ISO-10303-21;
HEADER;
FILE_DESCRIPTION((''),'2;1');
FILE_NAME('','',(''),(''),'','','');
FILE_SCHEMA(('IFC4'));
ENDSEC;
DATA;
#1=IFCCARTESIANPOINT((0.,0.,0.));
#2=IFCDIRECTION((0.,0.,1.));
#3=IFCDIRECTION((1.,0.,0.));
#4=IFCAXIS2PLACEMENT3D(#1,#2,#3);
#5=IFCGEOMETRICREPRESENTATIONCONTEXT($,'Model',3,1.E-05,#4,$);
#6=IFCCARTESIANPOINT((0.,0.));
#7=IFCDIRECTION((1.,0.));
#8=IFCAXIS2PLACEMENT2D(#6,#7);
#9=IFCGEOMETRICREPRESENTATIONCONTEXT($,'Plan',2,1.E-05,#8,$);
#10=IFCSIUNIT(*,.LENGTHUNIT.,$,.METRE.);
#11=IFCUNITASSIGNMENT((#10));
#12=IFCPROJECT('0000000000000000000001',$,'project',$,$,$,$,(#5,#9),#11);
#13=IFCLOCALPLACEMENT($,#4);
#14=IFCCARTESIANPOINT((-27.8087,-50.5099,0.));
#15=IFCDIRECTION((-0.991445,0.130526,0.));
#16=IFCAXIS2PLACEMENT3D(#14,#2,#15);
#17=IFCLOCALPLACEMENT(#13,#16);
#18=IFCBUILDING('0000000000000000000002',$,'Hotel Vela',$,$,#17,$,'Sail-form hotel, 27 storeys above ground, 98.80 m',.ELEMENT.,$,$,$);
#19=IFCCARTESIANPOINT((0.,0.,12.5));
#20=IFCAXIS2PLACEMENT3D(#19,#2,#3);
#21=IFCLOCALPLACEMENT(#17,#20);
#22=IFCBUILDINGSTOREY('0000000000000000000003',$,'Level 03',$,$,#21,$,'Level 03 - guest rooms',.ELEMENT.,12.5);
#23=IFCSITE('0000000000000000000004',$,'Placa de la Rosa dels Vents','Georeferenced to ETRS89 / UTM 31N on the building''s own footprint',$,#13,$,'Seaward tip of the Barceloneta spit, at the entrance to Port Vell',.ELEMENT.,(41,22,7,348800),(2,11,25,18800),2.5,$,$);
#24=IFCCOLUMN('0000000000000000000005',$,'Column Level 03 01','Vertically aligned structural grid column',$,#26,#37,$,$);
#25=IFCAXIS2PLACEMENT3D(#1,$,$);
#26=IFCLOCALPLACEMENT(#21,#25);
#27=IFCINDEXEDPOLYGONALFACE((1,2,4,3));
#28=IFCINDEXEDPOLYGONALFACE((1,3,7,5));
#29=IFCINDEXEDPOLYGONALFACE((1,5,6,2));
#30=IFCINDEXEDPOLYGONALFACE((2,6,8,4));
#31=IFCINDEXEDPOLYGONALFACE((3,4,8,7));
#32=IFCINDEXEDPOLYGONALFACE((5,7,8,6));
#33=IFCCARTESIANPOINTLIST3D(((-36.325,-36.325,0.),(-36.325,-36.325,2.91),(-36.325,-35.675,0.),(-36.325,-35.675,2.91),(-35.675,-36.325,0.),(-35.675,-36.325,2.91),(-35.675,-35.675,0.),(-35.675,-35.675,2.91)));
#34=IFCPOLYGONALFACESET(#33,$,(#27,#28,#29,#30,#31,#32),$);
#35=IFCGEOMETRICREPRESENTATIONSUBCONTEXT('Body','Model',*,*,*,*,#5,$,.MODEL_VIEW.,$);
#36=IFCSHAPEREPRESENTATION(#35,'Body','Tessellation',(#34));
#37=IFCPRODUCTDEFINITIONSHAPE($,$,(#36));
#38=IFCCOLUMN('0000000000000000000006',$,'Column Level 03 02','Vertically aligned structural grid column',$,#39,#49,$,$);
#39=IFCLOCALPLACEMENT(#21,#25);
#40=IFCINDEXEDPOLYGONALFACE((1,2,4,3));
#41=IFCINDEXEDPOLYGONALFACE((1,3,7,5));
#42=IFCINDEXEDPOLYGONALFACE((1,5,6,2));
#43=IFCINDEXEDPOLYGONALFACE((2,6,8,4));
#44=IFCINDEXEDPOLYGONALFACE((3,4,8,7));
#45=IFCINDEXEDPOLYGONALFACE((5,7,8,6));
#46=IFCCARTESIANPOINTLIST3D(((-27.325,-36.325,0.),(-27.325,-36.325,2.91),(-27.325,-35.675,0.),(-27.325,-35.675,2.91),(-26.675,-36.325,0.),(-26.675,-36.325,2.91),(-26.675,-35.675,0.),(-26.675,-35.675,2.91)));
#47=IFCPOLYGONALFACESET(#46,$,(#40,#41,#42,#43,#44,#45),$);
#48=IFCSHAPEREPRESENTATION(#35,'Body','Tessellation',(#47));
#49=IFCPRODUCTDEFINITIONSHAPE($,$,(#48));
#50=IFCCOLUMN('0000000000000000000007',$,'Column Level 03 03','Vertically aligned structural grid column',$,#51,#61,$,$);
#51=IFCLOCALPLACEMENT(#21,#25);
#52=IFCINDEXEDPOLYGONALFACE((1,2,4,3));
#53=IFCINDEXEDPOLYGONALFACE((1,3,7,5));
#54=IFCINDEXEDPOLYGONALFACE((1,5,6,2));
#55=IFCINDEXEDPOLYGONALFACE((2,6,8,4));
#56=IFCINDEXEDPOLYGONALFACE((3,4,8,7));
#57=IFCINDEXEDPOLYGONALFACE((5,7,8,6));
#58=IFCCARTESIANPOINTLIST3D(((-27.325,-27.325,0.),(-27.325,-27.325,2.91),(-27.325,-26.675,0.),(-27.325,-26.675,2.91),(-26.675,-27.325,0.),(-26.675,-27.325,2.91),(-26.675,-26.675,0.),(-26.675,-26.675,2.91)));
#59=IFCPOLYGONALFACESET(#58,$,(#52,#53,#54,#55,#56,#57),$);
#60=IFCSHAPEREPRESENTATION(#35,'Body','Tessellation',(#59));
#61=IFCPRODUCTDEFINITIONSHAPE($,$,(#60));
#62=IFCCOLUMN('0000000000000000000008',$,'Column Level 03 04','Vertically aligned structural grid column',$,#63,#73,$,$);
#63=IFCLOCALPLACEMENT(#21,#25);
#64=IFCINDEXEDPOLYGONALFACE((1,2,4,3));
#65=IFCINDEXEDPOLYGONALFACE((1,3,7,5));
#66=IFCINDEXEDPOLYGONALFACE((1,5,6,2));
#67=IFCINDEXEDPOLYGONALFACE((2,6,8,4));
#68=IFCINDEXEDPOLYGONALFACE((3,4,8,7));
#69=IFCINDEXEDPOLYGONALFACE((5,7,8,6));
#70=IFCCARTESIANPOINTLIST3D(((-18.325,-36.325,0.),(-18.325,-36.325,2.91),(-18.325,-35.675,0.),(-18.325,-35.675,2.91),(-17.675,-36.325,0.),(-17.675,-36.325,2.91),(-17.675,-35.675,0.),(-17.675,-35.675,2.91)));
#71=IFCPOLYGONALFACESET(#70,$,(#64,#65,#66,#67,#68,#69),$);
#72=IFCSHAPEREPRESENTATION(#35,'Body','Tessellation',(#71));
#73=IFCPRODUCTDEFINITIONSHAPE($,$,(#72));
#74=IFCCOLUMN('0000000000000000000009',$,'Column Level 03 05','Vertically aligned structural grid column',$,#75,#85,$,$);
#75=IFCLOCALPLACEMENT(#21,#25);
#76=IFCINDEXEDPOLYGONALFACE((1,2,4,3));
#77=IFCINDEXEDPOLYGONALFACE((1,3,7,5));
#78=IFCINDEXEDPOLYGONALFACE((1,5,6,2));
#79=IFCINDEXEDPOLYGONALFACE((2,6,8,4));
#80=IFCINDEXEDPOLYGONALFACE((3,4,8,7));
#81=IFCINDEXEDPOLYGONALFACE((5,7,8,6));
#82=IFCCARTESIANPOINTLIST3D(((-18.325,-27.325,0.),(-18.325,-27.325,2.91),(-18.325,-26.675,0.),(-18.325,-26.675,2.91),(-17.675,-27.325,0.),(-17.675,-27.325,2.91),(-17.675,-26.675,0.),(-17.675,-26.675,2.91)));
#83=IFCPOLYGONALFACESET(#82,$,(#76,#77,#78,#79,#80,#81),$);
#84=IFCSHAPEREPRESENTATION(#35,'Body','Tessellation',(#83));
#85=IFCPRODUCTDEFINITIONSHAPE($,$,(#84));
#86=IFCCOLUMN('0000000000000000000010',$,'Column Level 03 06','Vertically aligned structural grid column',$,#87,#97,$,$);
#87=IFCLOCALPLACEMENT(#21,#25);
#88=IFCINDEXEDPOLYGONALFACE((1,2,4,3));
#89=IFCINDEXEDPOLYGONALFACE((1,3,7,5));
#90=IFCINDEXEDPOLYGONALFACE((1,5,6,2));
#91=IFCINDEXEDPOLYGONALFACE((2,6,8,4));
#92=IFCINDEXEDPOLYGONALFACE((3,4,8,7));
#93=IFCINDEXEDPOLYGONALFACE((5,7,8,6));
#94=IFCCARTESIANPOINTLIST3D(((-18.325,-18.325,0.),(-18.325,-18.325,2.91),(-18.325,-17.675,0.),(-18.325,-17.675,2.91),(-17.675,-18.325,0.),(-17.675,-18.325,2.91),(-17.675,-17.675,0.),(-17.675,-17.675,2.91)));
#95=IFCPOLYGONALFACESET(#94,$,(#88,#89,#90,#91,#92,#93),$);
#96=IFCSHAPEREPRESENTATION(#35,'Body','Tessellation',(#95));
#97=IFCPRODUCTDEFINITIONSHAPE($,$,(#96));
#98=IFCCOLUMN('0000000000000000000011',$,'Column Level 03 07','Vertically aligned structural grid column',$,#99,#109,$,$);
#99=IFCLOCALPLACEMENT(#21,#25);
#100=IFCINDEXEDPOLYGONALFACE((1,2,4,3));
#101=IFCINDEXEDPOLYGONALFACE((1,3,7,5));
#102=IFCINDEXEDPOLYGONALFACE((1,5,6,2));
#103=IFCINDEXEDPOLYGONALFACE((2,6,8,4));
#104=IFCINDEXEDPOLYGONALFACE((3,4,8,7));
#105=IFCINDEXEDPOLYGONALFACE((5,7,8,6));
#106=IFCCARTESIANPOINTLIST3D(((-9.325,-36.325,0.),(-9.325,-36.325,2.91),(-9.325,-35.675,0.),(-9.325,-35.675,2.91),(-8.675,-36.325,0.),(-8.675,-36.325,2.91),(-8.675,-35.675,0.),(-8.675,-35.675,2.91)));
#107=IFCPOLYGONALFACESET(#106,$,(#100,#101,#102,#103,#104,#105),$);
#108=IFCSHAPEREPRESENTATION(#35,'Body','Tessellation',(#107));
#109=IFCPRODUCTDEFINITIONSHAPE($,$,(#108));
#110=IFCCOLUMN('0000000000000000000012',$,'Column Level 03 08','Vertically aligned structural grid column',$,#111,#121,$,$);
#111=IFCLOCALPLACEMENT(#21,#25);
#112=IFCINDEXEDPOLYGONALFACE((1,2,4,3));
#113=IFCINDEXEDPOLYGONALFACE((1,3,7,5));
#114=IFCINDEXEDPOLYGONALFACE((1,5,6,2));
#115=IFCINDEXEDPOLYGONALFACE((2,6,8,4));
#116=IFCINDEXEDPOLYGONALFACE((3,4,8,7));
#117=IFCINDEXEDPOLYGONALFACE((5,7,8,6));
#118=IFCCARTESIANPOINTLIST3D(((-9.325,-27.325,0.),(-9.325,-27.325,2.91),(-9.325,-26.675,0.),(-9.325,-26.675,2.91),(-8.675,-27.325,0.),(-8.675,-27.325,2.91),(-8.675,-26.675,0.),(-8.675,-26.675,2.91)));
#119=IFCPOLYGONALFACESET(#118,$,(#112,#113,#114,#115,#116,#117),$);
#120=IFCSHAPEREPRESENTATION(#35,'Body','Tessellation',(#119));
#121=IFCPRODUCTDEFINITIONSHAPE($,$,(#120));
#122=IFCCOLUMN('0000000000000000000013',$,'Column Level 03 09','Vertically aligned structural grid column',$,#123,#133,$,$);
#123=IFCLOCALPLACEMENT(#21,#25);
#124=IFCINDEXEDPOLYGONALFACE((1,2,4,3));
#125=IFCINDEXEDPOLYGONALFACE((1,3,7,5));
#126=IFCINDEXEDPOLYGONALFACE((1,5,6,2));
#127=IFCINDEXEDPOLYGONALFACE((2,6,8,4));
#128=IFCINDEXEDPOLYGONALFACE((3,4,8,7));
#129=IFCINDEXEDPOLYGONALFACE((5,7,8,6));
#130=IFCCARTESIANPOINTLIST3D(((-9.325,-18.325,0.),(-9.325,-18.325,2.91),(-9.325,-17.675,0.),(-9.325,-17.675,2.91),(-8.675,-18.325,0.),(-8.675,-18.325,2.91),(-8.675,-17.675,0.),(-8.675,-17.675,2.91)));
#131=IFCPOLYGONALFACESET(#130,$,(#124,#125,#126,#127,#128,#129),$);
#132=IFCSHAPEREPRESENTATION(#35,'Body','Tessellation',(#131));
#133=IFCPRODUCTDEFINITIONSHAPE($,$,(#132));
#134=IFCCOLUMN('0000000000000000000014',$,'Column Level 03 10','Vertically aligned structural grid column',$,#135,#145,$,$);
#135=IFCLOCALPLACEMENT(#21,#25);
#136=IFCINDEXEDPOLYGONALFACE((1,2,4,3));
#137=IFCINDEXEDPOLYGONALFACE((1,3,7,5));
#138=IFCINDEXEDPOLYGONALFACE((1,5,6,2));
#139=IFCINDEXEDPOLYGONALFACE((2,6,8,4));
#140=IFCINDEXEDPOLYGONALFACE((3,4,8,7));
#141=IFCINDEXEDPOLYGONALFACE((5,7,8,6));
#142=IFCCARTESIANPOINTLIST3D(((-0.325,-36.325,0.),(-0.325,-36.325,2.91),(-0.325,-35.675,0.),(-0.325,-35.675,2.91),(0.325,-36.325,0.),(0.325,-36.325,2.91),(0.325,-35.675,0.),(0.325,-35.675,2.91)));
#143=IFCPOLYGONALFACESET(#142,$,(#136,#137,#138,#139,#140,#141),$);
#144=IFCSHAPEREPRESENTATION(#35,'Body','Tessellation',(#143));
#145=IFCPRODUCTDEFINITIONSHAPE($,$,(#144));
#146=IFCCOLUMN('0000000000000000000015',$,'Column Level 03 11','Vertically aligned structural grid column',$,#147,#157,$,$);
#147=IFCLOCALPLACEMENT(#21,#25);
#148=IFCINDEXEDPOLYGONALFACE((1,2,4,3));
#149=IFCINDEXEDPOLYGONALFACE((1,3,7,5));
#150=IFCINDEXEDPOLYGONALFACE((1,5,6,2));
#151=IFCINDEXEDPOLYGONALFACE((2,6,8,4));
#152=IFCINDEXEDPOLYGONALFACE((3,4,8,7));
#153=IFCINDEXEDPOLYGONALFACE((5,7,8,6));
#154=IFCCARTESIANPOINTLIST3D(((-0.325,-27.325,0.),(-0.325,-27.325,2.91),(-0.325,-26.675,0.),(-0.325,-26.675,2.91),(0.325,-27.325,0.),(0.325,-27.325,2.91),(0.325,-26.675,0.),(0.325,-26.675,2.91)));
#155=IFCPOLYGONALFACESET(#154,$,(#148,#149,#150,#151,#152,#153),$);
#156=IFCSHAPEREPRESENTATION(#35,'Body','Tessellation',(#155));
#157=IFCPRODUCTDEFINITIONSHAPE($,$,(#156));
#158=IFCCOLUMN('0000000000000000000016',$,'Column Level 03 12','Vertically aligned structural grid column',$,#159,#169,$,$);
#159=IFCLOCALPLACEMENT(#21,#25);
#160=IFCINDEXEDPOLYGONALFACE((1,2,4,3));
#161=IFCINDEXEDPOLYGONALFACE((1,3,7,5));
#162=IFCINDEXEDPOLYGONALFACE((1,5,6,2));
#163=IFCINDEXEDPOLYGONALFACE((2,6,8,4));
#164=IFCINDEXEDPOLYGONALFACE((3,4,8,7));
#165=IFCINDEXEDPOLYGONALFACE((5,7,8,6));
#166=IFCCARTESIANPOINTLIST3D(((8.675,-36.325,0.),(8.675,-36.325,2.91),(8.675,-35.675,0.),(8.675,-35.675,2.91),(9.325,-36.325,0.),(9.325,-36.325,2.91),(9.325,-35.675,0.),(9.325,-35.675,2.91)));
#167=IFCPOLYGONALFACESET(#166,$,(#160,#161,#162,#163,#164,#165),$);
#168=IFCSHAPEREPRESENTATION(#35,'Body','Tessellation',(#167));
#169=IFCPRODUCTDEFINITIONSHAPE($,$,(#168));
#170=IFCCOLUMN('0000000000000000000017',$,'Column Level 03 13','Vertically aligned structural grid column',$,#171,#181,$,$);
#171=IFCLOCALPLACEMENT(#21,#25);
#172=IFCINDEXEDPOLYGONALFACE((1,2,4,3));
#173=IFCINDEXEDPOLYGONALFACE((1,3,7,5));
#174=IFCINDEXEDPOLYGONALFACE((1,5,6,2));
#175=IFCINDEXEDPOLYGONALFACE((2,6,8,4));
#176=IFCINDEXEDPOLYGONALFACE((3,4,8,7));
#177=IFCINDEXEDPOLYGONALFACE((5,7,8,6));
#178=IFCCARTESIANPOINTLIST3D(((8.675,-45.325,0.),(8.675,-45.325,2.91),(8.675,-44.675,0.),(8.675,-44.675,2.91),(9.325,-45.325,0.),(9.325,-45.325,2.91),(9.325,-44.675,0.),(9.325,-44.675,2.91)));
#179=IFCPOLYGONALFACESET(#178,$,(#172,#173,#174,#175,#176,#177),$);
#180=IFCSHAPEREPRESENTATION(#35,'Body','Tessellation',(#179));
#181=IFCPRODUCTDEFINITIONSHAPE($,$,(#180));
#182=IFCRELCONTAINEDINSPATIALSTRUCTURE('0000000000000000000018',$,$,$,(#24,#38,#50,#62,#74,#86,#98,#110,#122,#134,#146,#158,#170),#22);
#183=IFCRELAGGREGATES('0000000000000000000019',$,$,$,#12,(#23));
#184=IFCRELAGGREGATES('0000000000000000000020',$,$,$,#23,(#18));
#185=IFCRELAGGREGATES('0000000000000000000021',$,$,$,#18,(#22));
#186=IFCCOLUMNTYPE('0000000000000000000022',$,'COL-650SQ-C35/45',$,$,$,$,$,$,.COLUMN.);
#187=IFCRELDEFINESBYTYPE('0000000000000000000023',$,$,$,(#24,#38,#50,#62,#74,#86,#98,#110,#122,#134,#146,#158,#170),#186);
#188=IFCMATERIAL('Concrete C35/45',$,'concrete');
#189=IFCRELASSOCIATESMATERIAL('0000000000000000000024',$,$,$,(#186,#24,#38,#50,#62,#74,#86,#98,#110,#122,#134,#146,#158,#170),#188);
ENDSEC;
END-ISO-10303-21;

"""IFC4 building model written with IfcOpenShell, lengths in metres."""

from ifc_helpers import new_model, si_unit, frame, origin_with_axes, origin_2d_with_axis, place, context, subcontext, project, spatial, line, indexed_curve, rectangle, outline, extrude, material, material_profile, profile_set, profile_usage, type_object, element, save


model = new_model("IFC4")

# Units and contexts
model_context = context("Model", 3, precision=1e-05, world=origin_with_axes())
plan_context = context("Plan", 2, precision=1e-05, world=origin_2d_with_axis())
body_context = subcontext(model_context, "Body", "Model", "MODEL_VIEW")
ifc_project = project(units=[si_unit("LENGTHUNIT", "METRE")], contexts=[model_context, plan_context])

# Site, building, storey
site_placement = place(None, origin_with_axes())
site = spatial("IfcSite", under=ifc_project, at=site_placement, Name="Placa de la Rosa dels Vents", Description="Georeferenced to ETRS89 / UTM 31N on the building's own footprint", LongName="Seaward tip of the Barceloneta spit, at the entrance to Port Vell", CompositionType="ELEMENT", RefLatitude=(41, 22, 7, 348800), RefLongitude=(2, 11, 25, 18800), RefElevation=2.5)
building_placement = place(site_placement, frame((-27.8087, -50.5099, 0.0), z_axis=(0.0, 0.0, 1.0), x_axis=(-0.991445, 0.130526, 0.0)))
building = spatial("IfcBuilding", under=site, at=building_placement, Name="Hotel Vela", LongName="Sail-form hotel, 27 storeys above ground, 98.80 m", CompositionType="ELEMENT")
storey_placement = place(building_placement, frame((0.0, 0.0, 12.5), z_axis=(0.0, 0.0, 1.0), x_axis=(1.0, 0.0, 0.0)))
storey = spatial("IfcBuildingStorey", under=building, at=storey_placement, Name="Level 03", LongName="Level 03 - guest rooms", CompositionType="ELEMENT", Elevation=12.5)

# Columns
ifc_material = material(Name="Concrete C35/45", Category="concrete")
ifc_material_profile = material_profile(ifc_material, rectangle(XDim=0.65, YDim=0.65))
ifc_profile_set = profile_set([ifc_material_profile], Name="COL-650SQ-C35/45")
ifc_profile_usage_1 = profile_usage(ifc_profile_set)
column_type = type_object("IfcColumnType", Name="COL-650SQ-C35/45", PredefinedType="COLUMN", material=ifc_profile_set)
column_1_placement = place(storey_placement, frame((-36.325, -36.325, 0.0), z_axis=(0.0, 0.0, 1.0), x_axis=(1.0, 0.0, 0.0)))
element("IfcColumn", 1, at=column_1_placement, inside=storey, type_object=column_type, material=ifc_profile_usage_1, Name="Column Level 03 01", Description="Vertically aligned structural grid column", context=body_context, shape_type="SweptSolid", body=[
    extrude(outline(indexed_curve([(0.0, 0.0), (0.65, 0.0), (0.65, 0.65), (0.0, 0.65)], segments=[line(1, 2, 3, 4, 1)])), origin_with_axes(), (0.0, 0.0, 1.0), 2.91),
])
ifc_profile_usage_2 = profile_usage(ifc_profile_set)
column_2_placement = place(storey_placement, frame((-27.325, -36.325, 0.0), z_axis=(0.0, 0.0, 1.0), x_axis=(1.0, 0.0, 0.0)))
element("IfcColumn", 2, at=column_2_placement, inside=storey, type_object=column_type, material=ifc_profile_usage_2, Name="Column Level 03 02", Description="Vertically aligned structural grid column", context=body_context, shape_type="SweptSolid", body=[
    extrude(outline(indexed_curve([(0.0, 0.0), (0.65, 0.0), (0.65, 0.65), (0.0, 0.65)], segments=[line(1, 2, 3, 4, 1)])), origin_with_axes(), (0.0, 0.0, 1.0), 2.91),
])
ifc_profile_usage_3 = profile_usage(ifc_profile_set)
column_3_placement = place(storey_placement, frame((-27.325, -27.325, 0.0), z_axis=(0.0, 0.0, 1.0), x_axis=(1.0, 0.0, 0.0)))
element("IfcColumn", 3, at=column_3_placement, inside=storey, type_object=column_type, material=ifc_profile_usage_3, Name="Column Level 03 03", Description="Vertically aligned structural grid column", context=body_context, shape_type="SweptSolid", body=[
    extrude(outline(indexed_curve([(0.0, 0.0), (0.65, 0.0), (0.65, 0.65), (0.0, 0.65)], segments=[line(1, 2, 3, 4, 1)])), origin_with_axes(), (0.0, 0.0, 1.0), 2.91),
])
ifc_profile_usage_4 = profile_usage(ifc_profile_set)
column_4_placement = place(storey_placement, frame((-18.325, -36.325, 0.0), z_axis=(0.0, 0.0, 1.0), x_axis=(1.0, 0.0, 0.0)))
element("IfcColumn", 4, at=column_4_placement, inside=storey, type_object=column_type, material=ifc_profile_usage_4, Name="Column Level 03 04", Description="Vertically aligned structural grid column", context=body_context, shape_type="SweptSolid", body=[
    extrude(outline(indexed_curve([(0.0, 0.0), (0.65, 0.0), (0.65, 0.65), (0.0, 0.65)], segments=[line(1, 2, 3, 4, 1)])), origin_with_axes(), (0.0, 0.0, 1.0), 2.91),
])
ifc_profile_usage_5 = profile_usage(ifc_profile_set)
column_5_placement = place(storey_placement, frame((-18.325, -27.325, 0.0), z_axis=(0.0, 0.0, 1.0), x_axis=(1.0, 0.0, 0.0)))
element("IfcColumn", 5, at=column_5_placement, inside=storey, type_object=column_type, material=ifc_profile_usage_5, Name="Column Level 03 05", Description="Vertically aligned structural grid column", context=body_context, shape_type="SweptSolid", body=[
    extrude(outline(indexed_curve([(0.0, 0.0), (0.65, 0.0), (0.65, 0.65), (0.0, 0.65)], segments=[line(1, 2, 3, 4, 1)])), origin_with_axes(), (0.0, 0.0, 1.0), 2.91),
])
ifc_profile_usage_6 = profile_usage(ifc_profile_set)
column_6_placement = place(storey_placement, frame((-18.325, -18.325, 0.0), z_axis=(0.0, 0.0, 1.0), x_axis=(1.0, 0.0, 0.0)))
element("IfcColumn", 6, at=column_6_placement, inside=storey, type_object=column_type, material=ifc_profile_usage_6, Name="Column Level 03 06", Description="Vertically aligned structural grid column", context=body_context, shape_type="SweptSolid", body=[
    extrude(outline(indexed_curve([(0.0, 0.0), (0.65, 0.0), (0.65, 0.65), (0.0, 0.65)], segments=[line(1, 2, 3, 4, 1)])), origin_with_axes(), (0.0, 0.0, 1.0), 2.91),
])
ifc_profile_usage_7 = profile_usage(ifc_profile_set)
column_7_placement = place(storey_placement, frame((-9.325, -36.325, 0.0), z_axis=(0.0, 0.0, 1.0), x_axis=(1.0, 0.0, 0.0)))
element("IfcColumn", 7, at=column_7_placement, inside=storey, type_object=column_type, material=ifc_profile_usage_7, Name="Column Level 03 07", Description="Vertically aligned structural grid column", context=body_context, shape_type="SweptSolid", body=[
    extrude(outline(indexed_curve([(0.0, 0.0), (0.65, 0.0), (0.65, 0.65), (0.0, 0.65)], segments=[line(1, 2, 3, 4, 1)])), origin_with_axes(), (0.0, 0.0, 1.0), 2.91),
])
ifc_profile_usage_8 = profile_usage(ifc_profile_set)
column_8_placement = place(storey_placement, frame((-9.325, -27.325, 0.0), z_axis=(0.0, 0.0, 1.0), x_axis=(1.0, 0.0, 0.0)))
element("IfcColumn", 8, at=column_8_placement, inside=storey, type_object=column_type, material=ifc_profile_usage_8, Name="Column Level 03 08", Description="Vertically aligned structural grid column", context=body_context, shape_type="SweptSolid", body=[
    extrude(outline(indexed_curve([(0.0, 0.0), (0.65, 0.0), (0.65, 0.65), (0.0, 0.65)], segments=[line(1, 2, 3, 4, 1)])), origin_with_axes(), (0.0, 0.0, 1.0), 2.91),
])
ifc_profile_usage_9 = profile_usage(ifc_profile_set)
column_9_placement = place(storey_placement, frame((-9.325, -18.325, 0.0), z_axis=(0.0, 0.0, 1.0), x_axis=(1.0, 0.0, 0.0)))
element("IfcColumn", 9, at=column_9_placement, inside=storey, type_object=column_type, material=ifc_profile_usage_9, Name="Column Level 03 09", Description="Vertically aligned structural grid column", context=body_context, shape_type="SweptSolid", body=[
    extrude(outline(indexed_curve([(0.0, 0.0), (0.65, 0.0), (0.65, 0.65), (0.0, 0.65)], segments=[line(1, 2, 3, 4, 1)])), origin_with_axes(), (0.0, 0.0, 1.0), 2.91),
])
ifc_profile_usage_10 = profile_usage(ifc_profile_set)
column_10_placement = place(storey_placement, frame((-0.325, -36.325, 0.0), z_axis=(0.0, 0.0, 1.0), x_axis=(1.0, 0.0, 0.0)))
element("IfcColumn", 10, at=column_10_placement, inside=storey, type_object=column_type, material=ifc_profile_usage_10, Name="Column Level 03 10", Description="Vertically aligned structural grid column", context=body_context, shape_type="SweptSolid", body=[
    extrude(outline(indexed_curve([(0.0, 0.0), (0.65, 0.0), (0.65, 0.65), (0.0, 0.65)], segments=[line(1, 2, 3, 4, 1)])), origin_with_axes(), (0.0, 0.0, 1.0), 2.91),
])
ifc_profile_usage_11 = profile_usage(ifc_profile_set)
column_11_placement = place(storey_placement, frame((-0.325, -27.325, 0.0), z_axis=(0.0, 0.0, 1.0), x_axis=(1.0, 0.0, 0.0)))
element("IfcColumn", 11, at=column_11_placement, inside=storey, type_object=column_type, material=ifc_profile_usage_11, Name="Column Level 03 11", Description="Vertically aligned structural grid column", context=body_context, shape_type="SweptSolid", body=[
    extrude(outline(indexed_curve([(0.0, 0.0), (0.65, 0.0), (0.65, 0.65), (0.0, 0.65)], segments=[line(1, 2, 3, 4, 1)])), origin_with_axes(), (0.0, 0.0, 1.0), 2.91),
])
ifc_profile_usage_12 = profile_usage(ifc_profile_set)
column_12_placement = place(storey_placement, frame((8.675, -36.325, 0.0), z_axis=(0.0, 0.0, 1.0), x_axis=(1.0, 0.0, 0.0)))
element("IfcColumn", 12, at=column_12_placement, inside=storey, type_object=column_type, material=ifc_profile_usage_12, Name="Column Level 03 12", Description="Vertically aligned structural grid column", context=body_context, shape_type="SweptSolid", body=[
    extrude(outline(indexed_curve([(0.0, 0.0), (0.65, 0.0), (0.65, 0.65), (0.0, 0.65)], segments=[line(1, 2, 3, 4, 1)])), origin_with_axes(), (0.0, 0.0, 1.0), 2.91),
])
ifc_profile_usage_13 = profile_usage(ifc_profile_set)
column_13_placement = place(storey_placement, frame((8.675, -45.325, 0.0), z_axis=(0.0, 0.0, 1.0), x_axis=(1.0, 0.0, 0.0)))
element("IfcColumn", 13, at=column_13_placement, inside=storey, type_object=column_type, material=ifc_profile_usage_13, Name="Column Level 03 13", Description="Vertically aligned structural grid column", context=body_context, shape_type="SweptSolid", body=[
    extrude(outline(indexed_curve([(0.0, 0.0), (0.65, 0.0), (0.65, 0.65), (0.0, 0.65)], segments=[line(1, 2, 3, 4, 1)])), origin_with_axes(), (0.0, 0.0, 1.0), 2.91),
])

save(model, "model.ifc")
